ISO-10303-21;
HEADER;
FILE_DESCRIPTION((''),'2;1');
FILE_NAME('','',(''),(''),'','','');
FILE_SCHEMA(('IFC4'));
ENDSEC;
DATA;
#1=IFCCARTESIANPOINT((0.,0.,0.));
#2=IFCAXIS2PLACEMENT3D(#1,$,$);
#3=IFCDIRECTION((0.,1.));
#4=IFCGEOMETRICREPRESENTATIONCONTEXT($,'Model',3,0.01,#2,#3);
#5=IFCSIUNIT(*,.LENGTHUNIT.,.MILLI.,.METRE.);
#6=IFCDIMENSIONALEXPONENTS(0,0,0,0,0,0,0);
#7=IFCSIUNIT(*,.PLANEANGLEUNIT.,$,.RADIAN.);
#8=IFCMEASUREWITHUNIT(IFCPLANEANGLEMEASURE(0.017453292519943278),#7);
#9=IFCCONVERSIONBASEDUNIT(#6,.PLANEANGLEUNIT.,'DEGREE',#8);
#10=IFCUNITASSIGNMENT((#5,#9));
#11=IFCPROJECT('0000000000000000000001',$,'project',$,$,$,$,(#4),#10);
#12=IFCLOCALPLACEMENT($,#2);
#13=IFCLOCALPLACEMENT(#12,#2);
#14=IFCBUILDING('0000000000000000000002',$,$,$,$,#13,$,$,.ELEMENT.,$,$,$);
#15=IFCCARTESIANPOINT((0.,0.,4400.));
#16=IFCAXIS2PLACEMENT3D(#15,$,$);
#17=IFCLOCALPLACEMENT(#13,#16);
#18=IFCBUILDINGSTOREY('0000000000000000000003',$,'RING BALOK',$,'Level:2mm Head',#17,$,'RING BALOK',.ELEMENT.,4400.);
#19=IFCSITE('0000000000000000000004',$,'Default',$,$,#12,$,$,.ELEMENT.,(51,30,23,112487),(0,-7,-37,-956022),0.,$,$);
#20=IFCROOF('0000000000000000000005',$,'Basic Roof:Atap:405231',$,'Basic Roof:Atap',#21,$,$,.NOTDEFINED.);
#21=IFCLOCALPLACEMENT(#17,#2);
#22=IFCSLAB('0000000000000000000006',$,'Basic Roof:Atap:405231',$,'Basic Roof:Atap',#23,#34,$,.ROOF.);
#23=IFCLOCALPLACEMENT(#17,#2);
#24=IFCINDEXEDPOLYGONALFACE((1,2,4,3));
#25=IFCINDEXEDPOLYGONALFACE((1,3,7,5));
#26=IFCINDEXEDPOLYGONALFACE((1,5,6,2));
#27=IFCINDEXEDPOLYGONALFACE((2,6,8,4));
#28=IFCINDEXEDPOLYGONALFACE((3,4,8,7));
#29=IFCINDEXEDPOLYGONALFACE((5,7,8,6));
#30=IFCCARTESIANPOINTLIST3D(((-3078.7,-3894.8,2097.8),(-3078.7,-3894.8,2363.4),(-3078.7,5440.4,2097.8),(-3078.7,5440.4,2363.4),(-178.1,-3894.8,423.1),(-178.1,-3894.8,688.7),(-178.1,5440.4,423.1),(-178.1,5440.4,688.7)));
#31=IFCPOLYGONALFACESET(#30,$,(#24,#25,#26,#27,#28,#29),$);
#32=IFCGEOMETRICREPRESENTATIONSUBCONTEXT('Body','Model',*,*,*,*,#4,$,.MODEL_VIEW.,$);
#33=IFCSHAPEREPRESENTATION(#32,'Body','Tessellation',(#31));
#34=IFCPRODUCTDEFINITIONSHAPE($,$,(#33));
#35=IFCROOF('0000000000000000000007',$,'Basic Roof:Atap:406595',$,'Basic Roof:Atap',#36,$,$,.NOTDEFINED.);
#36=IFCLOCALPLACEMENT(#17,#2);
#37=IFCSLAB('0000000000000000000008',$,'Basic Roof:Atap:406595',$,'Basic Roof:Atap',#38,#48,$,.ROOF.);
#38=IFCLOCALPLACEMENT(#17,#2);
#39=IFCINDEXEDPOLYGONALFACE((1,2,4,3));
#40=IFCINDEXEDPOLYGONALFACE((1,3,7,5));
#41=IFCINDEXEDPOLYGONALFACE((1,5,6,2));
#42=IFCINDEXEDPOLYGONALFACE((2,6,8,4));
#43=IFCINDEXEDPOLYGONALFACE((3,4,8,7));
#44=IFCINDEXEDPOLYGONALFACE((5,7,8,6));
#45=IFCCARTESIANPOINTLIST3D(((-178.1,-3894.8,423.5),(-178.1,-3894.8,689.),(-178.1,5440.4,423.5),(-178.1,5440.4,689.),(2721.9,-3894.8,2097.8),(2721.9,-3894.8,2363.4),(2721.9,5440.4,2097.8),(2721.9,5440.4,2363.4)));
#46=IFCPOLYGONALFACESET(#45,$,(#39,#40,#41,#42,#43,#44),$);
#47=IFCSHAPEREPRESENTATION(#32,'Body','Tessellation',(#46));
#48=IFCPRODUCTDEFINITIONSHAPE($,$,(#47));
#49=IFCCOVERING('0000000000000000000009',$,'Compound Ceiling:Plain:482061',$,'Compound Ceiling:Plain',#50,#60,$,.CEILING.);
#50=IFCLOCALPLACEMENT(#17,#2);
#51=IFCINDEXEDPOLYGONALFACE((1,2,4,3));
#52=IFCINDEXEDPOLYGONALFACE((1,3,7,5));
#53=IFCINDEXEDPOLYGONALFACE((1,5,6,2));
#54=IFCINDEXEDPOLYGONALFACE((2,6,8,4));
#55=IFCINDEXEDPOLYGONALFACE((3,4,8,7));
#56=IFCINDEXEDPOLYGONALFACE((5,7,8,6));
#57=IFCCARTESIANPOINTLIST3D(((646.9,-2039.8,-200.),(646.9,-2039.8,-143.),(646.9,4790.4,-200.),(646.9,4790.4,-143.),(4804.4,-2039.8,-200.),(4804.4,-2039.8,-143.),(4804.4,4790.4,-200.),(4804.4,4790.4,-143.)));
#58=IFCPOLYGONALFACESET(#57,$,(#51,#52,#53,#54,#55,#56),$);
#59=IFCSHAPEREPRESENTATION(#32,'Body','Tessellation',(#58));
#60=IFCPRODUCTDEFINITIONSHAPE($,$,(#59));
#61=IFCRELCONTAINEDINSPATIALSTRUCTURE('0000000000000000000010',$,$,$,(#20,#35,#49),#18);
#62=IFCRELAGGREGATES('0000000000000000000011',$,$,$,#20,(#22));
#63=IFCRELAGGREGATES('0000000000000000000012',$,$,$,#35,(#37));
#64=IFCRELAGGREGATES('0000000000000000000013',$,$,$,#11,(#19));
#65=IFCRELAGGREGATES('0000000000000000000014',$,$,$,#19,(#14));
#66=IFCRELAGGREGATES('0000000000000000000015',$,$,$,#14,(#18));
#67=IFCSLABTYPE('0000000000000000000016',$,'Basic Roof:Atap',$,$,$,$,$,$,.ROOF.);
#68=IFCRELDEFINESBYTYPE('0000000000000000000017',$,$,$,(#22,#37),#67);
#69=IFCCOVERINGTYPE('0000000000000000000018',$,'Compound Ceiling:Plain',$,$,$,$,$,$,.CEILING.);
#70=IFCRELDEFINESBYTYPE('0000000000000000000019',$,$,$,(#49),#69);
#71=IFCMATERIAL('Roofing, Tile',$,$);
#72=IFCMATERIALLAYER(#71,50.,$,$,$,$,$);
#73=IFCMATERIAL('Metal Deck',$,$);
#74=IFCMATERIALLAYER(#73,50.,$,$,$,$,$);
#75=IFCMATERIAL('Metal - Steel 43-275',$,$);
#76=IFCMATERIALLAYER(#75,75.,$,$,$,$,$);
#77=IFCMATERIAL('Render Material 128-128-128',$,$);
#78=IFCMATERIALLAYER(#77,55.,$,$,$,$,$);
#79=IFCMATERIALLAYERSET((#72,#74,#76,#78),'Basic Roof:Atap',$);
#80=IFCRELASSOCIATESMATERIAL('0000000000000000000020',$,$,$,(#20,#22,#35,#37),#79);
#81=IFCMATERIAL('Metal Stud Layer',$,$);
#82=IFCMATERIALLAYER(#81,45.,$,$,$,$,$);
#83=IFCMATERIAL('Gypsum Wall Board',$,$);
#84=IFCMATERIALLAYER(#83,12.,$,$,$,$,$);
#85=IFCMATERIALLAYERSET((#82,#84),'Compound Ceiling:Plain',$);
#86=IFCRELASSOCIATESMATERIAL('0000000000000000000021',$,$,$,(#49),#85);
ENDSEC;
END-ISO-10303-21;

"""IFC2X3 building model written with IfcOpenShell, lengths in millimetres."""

from ifc_helpers import new_model, entity, si_unit, converted_unit, direction, frame, frame_2d, origin, origin_2d_with_axis, place, context, subcontext, project, spatial, rectangle, extrude, material, layer, layer_set, layer_usage, type_object, element, aggregate, save


model = new_model("IFC2X3")

# Units and contexts
model_context = context("Model", 3, precision=0.01, world=origin(), true_north=direction((0.0, 1.0)))
body_context = subcontext(model_context, "Body", "Model", "MODEL_VIEW")
ifc_project = project(units=[si_unit("LENGTHUNIT", "METRE", prefix="MILLI"), converted_unit("PLANEANGLEUNIT", "DEGREE", entity("IfcPlaneAngleMeasure", 0.017453292519943278), si_unit("PLANEANGLEUNIT", "RADIAN"), dimensions=[0, 0, 0, 0, 0, 0, 0])], contexts=[model_context])

# Site, building, storey
site_placement = place(None, origin())
site = spatial("IfcSite", under=ifc_project, at=site_placement, Name="Default", CompositionType="ELEMENT", RefLatitude=(51, 30, 23, 112487), RefLongitude=(0, -7, -37, -956022), RefElevation=0.0)
building_placement = place(site_placement, origin())
building = spatial("IfcBuilding", under=site, at=building_placement, CompositionType="ELEMENT")
storey_placement = place(building_placement, frame((0.0, 0.0, 4400.0)))
storey = spatial("IfcBuildingStorey", under=building, at=storey_placement, Name="RING BALOK", ObjectType="Level:2mm Head", LongName="RING BALOK", CompositionType="ELEMENT", Elevation=4400.0)

# Roofs, slabs
ifc_material_1 = material(Name="Roofing, Tile")
ifc_layer_1 = layer(ifc_material_1, 50.0)
ifc_material_2 = material(Name="Metal Deck")
ifc_layer_2 = layer(ifc_material_2, 50.0)
ifc_material_3 = material(Name="Metal - Steel 43-275")
ifc_layer_3 = layer(ifc_material_3, 75.0)
ifc_material_4 = material(Name="Render Material 128-128-128")
ifc_layer_4 = layer(ifc_material_4, 55.0)
ifc_layer_set_1 = layer_set([ifc_layer_1, ifc_layer_2, ifc_layer_3, ifc_layer_4], Name="Basic Roof:Atap")
roof_1_placement = place(storey_placement, frame((-3078.7, -3894.8, 423.1)))
roof_1 = element("IfcRoof", 1, at=roof_1_placement, inside=storey, material=ifc_layer_set_1, Name="Basic Roof:Atap:405231", ObjectType="Basic Roof:Atap", ShapeType="NOTDEFINED")
slab_type = type_object("IfcSlabType", Name="Basic Roof:Atap", PredefinedType="ROOF")
slab_1_placement = place(roof_1_placement, origin())
slab_1 = element("IfcSlab", 2, at=slab_1_placement, type_object=slab_type, material=ifc_layer_set_1, Name="Basic Roof:Atap:405231", ObjectType="Basic Roof:Atap", PredefinedType="ROOF", context=body_context, shape_type="SweptSolid", body=[
    extrude(rectangle(XDim=3349.3, YDim=9335.2, at=origin_2d_with_axis()), frame((1450.3, 4667.6, 837.3), z_axis=(0.5, 0.0, 0.866025), x_axis=(0.866025, 0.0, -0.5)), (-0.5, 0.0, 0.866025), 265.6),
])
aggregate(roof_1, [slab_1])
roof_2_placement = place(storey_placement, frame((-178.1, -3894.8, 423.5)))
roof_2 = element("IfcRoof", 3, at=roof_2_placement, inside=storey, material=ifc_layer_set_1, Name="Basic Roof:Atap:406595", ObjectType="Basic Roof:Atap", ShapeType="NOTDEFINED")
slab_2_placement = place(roof_2_placement, origin())
slab_2 = element("IfcSlab", 4, at=slab_2_placement, type_object=slab_type, material=ifc_layer_set_1, Name="Basic Roof:Atap:406595", ObjectType="Basic Roof:Atap", PredefinedType="ROOF", context=body_context, shape_type="SweptSolid", body=[
    extrude(rectangle(XDim=3348.6, YDim=9335.2, at=frame_2d((0.0, 0.0), x_axis=(1.0, 0.0))), frame((1450.0, 4667.6, 837.2), z_axis=(-0.5, 0.0, 0.866025), x_axis=(0.866025, 0.0, 0.5)), (0.5, 0.0, 0.866025), 265.6),
])
aggregate(roof_2, [slab_2])

# Covering
ifc_material_5 = material(Name="Metal Stud Layer")
ifc_layer_5 = layer(ifc_material_5, 45.0)
ifc_material_6 = material(Name="Gypsum Wall Board")
ifc_layer_6 = layer(ifc_material_6, 12.0)
ifc_layer_set_2 = layer_set([ifc_layer_5, ifc_layer_6], Name="Compound Ceiling:Plain")
ifc_layer_usage = layer_usage(ifc_layer_set_2, "AXIS3", "NEGATIVE", 57.0)
covering_type = type_object("IfcCoveringType", Name="Compound Ceiling:Plain", PredefinedType="CEILING")
covering_placement = place(storey_placement, origin())
element("IfcCovering", 5, at=covering_placement, inside=storey, type_object=covering_type, material=ifc_layer_usage, Name="Compound Ceiling:Plain:482061", ObjectType="Compound Ceiling:Plain", PredefinedType="CEILING", context=body_context, shape_type="SweptSolid", body=[
    extrude(rectangle(XDim=4157.5, YDim=6830.2, at=origin_2d_with_axis()), frame((2725.7, 1375.3, -200.0), z_axis=(0.0, 0.0, 1.0), x_axis=(-1.0, 0.0, 0.0)), (0.0, 0.0, 1.0), 57.0),
])

save(model, "model.ifc")
